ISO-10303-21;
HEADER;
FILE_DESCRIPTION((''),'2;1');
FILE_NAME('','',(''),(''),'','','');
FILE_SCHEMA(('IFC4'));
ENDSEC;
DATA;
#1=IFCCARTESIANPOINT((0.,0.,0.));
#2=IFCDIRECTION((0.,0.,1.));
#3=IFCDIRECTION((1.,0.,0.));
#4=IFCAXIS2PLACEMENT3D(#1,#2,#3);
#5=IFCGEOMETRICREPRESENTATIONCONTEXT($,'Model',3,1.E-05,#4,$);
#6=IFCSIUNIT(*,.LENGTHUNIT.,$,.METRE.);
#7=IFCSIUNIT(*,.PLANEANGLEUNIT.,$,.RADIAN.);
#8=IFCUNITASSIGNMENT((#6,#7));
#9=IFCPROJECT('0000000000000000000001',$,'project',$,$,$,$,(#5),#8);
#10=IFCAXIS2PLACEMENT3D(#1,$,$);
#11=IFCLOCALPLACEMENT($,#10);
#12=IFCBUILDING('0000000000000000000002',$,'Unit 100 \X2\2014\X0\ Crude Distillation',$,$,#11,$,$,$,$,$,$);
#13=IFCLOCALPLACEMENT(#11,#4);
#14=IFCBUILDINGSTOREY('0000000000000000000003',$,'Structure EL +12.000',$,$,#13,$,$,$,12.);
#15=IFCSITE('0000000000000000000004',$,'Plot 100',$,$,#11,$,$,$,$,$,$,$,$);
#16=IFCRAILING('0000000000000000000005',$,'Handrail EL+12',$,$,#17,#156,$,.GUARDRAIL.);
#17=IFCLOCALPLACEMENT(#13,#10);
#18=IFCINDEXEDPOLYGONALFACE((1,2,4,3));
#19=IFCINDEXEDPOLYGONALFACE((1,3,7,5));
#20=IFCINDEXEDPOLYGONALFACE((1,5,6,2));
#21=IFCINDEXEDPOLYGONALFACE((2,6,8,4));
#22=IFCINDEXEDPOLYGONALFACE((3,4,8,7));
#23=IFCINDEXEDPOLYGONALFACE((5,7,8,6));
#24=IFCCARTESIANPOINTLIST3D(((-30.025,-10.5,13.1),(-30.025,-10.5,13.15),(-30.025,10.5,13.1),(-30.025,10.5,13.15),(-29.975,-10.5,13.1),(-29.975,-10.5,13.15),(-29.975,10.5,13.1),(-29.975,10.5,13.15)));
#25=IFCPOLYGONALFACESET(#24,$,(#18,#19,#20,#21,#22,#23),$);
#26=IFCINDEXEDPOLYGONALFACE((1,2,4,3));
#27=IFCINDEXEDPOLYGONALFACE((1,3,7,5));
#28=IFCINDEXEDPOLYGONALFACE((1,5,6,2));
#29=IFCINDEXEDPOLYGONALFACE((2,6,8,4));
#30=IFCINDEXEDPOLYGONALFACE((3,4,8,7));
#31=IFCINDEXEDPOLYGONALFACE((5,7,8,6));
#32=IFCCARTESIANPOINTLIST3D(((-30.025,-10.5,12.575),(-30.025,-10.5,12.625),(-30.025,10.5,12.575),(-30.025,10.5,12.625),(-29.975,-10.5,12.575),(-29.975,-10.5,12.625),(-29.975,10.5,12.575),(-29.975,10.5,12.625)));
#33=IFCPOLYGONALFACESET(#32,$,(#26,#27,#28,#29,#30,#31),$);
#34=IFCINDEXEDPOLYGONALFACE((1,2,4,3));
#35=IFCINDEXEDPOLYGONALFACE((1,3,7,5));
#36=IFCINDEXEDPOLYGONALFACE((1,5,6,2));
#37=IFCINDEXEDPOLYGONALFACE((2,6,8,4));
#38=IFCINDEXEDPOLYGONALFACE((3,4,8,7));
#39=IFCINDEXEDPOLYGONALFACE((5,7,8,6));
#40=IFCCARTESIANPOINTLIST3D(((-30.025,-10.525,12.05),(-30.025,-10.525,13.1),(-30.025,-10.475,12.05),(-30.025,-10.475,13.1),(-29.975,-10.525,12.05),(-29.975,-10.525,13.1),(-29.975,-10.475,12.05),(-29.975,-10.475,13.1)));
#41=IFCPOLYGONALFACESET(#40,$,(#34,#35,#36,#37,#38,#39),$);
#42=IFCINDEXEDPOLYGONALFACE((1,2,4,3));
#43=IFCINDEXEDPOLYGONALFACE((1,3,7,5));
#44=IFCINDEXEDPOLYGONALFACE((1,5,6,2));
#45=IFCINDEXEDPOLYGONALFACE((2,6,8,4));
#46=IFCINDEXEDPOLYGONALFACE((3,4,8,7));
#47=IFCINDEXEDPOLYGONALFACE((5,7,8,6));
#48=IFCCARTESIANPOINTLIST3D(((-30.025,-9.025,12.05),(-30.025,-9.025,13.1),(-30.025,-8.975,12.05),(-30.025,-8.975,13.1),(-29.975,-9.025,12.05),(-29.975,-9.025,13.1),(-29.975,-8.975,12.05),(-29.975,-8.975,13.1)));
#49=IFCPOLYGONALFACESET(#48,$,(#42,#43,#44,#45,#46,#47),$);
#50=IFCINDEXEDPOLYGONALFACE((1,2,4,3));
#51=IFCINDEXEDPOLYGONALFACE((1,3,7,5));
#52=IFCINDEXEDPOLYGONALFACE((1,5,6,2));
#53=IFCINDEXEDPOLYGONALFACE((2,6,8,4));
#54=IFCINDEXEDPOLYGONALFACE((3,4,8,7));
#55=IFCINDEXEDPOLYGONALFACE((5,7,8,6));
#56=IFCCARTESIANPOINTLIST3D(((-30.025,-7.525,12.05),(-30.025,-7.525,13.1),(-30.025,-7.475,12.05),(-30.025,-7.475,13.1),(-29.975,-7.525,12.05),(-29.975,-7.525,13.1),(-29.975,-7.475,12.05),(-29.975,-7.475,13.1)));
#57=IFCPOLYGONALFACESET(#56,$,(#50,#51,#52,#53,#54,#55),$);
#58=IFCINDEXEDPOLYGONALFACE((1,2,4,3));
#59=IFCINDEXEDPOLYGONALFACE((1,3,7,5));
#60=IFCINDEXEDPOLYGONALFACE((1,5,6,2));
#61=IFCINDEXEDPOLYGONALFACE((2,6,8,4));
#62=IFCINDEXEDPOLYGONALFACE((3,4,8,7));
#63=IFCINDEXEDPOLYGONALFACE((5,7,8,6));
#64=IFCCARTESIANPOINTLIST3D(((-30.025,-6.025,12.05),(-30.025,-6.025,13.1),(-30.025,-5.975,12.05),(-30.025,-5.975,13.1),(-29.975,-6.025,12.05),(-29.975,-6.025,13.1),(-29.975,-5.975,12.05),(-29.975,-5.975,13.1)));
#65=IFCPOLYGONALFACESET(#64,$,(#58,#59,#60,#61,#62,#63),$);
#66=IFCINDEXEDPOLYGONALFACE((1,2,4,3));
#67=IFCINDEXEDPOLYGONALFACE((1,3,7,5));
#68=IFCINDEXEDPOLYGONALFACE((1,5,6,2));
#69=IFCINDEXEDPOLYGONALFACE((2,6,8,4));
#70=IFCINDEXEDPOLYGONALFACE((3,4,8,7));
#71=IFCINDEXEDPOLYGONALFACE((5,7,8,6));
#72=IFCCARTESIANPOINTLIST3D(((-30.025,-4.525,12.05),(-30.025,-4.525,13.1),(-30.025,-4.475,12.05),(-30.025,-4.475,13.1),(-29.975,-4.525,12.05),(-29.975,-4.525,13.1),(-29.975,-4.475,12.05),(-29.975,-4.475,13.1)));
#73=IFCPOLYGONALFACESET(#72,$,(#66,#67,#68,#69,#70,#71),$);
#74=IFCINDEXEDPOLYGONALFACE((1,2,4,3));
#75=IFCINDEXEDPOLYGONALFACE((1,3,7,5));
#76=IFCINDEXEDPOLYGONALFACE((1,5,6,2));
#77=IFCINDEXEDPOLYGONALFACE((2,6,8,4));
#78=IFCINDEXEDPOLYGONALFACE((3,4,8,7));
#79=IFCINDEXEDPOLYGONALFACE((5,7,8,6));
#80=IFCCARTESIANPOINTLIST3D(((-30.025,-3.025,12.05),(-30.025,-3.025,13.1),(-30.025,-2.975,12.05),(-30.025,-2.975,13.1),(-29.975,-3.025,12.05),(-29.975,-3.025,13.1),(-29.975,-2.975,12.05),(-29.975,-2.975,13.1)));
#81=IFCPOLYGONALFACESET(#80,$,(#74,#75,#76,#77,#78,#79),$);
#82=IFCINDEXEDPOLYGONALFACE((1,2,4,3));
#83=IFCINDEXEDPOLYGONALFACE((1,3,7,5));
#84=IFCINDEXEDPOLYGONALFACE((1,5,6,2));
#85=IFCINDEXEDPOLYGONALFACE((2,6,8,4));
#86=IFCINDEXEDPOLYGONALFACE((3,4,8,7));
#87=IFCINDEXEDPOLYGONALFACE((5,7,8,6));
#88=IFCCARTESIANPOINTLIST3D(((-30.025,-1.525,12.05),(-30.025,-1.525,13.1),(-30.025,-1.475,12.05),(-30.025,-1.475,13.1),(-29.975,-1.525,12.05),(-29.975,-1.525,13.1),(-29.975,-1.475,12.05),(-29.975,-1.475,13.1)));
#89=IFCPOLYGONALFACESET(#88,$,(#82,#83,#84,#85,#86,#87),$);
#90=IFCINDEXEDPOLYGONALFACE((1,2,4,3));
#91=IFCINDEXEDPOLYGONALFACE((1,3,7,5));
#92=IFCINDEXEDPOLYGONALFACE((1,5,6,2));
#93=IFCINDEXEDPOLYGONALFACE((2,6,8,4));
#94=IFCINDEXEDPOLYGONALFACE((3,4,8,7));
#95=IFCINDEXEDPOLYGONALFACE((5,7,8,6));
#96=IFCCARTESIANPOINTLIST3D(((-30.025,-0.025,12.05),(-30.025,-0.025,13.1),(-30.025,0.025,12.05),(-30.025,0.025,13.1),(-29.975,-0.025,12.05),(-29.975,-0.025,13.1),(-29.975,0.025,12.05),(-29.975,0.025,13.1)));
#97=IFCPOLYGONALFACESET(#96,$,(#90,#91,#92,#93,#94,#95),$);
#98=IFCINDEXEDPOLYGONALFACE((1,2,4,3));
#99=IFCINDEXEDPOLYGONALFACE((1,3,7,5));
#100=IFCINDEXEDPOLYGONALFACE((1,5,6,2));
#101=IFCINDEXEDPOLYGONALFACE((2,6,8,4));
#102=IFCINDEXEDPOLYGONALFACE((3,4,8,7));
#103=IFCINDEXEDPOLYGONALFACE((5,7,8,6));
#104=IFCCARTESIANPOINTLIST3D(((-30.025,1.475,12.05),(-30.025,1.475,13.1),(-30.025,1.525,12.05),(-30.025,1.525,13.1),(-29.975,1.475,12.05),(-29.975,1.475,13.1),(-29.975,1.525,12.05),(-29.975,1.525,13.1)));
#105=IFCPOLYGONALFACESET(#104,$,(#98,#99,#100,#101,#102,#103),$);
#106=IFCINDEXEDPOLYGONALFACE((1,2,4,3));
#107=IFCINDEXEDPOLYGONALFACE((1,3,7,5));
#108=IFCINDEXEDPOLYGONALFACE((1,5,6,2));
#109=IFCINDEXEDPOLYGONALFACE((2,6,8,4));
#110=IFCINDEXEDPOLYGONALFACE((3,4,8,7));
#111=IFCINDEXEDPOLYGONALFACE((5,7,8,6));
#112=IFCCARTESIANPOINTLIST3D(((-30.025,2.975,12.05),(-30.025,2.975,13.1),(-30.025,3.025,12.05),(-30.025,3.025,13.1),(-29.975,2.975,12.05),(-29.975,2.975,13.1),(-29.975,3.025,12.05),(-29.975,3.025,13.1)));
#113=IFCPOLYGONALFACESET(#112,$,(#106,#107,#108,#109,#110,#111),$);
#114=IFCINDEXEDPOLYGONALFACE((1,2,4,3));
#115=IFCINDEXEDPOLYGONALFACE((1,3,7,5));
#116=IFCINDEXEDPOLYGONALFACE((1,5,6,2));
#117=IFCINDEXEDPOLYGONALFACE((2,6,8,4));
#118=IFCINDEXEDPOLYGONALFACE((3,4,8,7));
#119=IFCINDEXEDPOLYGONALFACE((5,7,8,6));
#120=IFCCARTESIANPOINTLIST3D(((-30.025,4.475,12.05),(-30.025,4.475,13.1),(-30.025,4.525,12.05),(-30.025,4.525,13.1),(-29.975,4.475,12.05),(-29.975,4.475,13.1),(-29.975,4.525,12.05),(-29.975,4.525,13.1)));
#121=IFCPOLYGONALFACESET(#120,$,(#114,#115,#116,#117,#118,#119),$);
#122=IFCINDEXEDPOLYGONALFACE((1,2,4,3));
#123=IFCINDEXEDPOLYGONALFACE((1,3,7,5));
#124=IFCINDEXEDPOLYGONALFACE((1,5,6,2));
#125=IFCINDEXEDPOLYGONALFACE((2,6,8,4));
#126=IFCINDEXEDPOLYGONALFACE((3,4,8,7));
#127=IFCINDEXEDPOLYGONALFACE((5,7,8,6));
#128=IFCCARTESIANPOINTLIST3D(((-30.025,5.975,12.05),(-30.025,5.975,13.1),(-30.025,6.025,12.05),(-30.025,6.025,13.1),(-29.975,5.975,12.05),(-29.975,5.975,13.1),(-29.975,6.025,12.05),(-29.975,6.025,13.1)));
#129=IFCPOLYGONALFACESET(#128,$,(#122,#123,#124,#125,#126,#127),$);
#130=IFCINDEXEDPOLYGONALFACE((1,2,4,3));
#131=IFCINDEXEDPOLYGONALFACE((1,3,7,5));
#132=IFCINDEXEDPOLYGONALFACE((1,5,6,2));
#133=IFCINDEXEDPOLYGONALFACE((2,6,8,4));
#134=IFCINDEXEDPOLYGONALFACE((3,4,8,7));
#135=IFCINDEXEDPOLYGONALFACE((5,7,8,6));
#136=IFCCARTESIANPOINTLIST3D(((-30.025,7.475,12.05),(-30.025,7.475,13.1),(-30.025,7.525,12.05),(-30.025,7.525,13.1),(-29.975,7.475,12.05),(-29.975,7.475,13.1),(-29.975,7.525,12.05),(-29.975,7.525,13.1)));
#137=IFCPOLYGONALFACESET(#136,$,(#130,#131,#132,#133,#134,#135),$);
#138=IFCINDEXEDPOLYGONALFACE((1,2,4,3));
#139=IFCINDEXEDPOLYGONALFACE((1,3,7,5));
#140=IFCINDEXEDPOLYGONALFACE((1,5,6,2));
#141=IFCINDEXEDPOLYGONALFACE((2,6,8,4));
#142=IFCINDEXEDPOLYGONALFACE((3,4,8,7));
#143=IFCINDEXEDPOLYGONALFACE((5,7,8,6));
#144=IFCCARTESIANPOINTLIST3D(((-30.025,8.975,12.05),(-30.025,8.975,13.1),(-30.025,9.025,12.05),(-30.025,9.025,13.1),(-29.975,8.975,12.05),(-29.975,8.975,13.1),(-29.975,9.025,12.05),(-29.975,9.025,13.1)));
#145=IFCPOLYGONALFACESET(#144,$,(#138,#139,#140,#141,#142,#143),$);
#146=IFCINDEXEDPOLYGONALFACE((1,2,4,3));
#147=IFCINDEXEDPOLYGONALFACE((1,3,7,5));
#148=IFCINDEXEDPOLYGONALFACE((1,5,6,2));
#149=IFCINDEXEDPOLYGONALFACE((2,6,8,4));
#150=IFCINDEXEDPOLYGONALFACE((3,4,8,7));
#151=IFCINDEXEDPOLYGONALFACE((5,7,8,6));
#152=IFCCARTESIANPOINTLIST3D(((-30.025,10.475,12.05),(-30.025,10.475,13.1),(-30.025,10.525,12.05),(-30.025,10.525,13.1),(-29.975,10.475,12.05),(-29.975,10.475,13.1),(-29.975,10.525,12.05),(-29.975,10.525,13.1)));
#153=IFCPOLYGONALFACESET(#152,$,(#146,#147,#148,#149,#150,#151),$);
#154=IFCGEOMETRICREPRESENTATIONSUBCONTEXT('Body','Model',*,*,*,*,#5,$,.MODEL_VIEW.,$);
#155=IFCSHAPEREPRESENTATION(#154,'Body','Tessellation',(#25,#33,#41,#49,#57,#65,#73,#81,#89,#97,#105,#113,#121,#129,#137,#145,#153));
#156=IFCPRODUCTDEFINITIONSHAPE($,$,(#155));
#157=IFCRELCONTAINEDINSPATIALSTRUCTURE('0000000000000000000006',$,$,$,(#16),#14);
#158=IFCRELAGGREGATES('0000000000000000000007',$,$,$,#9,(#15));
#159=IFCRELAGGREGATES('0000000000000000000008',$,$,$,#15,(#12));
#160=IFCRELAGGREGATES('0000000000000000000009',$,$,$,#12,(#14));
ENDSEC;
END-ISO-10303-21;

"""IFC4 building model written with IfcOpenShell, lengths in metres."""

from ifc_helpers import new_model, si_unit, frame, origin, origin_with_axes, origin_2d, place, context, subcontext, project, spatial, rectangle, extrude, element, save


model = new_model("IFC4")

# Units and contexts
model_context = context("Model", 3, precision=1e-05, world=origin_with_axes())
body_context = subcontext(model_context, "Body", "Model", "MODEL_VIEW")
ifc_project = project(units=[si_unit("LENGTHUNIT", "METRE"), si_unit("PLANEANGLEUNIT", "RADIAN")], contexts=[model_context])

# Site, building, storey
placement = place(None, origin())
site = spatial("IfcSite", under=ifc_project, at=placement, Name="Plot 100")
building = spatial("IfcBuilding", under=site, at=placement, Name="Unit 100 — Crude Distillation")
storey_placement = place(placement, origin_with_axes())
storey = spatial("IfcBuildingStorey", under=building, at=storey_placement, Name="Structure EL +12.000", Elevation=12.0)

# Railing
railing_1_placement = place(storey_placement, origin_with_axes())
element("IfcRailing", 1, at=railing_1_placement, inside=storey, Name="Handrail EL+12", PredefinedType="GUARDRAIL", context=body_context, shape_type="SweptSolid", body=[
    extrude(rectangle(XDim=0.05, YDim=0.05, at=origin_2d()), frame((-30.0, -10.5, 13.125), z_axis=(0.0, 1.0, 0.0), x_axis=(-1.0, 0.0, 0.0)), (0.0, 0.0, 1.0), 21.0),
    extrude(rectangle(XDim=0.05, YDim=0.05, at=origin_2d()), frame((-30.0, -10.5, 12.6), z_axis=(0.0, 1.0, 0.0), x_axis=(-1.0, 0.0, 0.0)), (0.0, 0.0, 1.0), 21.0),
    extrude(rectangle(XDim=0.05, YDim=0.05, at=origin_2d()), frame((-30.0, -10.5, 12.05), z_axis=(0.0, 0.0, 1.0), x_axis=(1.0, 0.0, 0.0)), (0.0, 0.0, 1.0), 1.05),
    extrude(rectangle(XDim=0.05, YDim=0.05, at=origin_2d()), frame((-30.0, -9.0, 12.05), z_axis=(0.0, 0.0, 1.0), x_axis=(1.0, 0.0, 0.0)), (0.0, 0.0, 1.0), 1.05),
    extrude(rectangle(XDim=0.05, YDim=0.05, at=origin_2d()), frame((-30.0, -7.5, 12.05), z_axis=(0.0, 0.0, 1.0), x_axis=(1.0, 0.0, 0.0)), (0.0, 0.0, 1.0), 1.05),
    extrude(rectangle(XDim=0.05, YDim=0.05, at=origin_2d()), frame((-30.0, -6.0, 12.05), z_axis=(0.0, 0.0, 1.0), x_axis=(1.0, 0.0, 0.0)), (0.0, 0.0, 1.0), 1.05),
    extrude(rectangle(XDim=0.05, YDim=0.05, at=origin_2d()), frame((-30.0, -4.5, 12.05), z_axis=(0.0, 0.0, 1.0), x_axis=(1.0, 0.0, 0.0)), (0.0, 0.0, 1.0), 1.05),
    extrude(rectangle(XDim=0.05, YDim=0.05, at=origin_2d()), frame((-30.0, -3.0, 12.05), z_axis=(0.0, 0.0, 1.0), x_axis=(1.0, 0.0, 0.0)), (0.0, 0.0, 1.0), 1.05),
    extrude(rectangle(XDim=0.05, YDim=0.05, at=origin_2d()), frame((-30.0, -1.5, 12.05), z_axis=(0.0, 0.0, 1.0), x_axis=(1.0, 0.0, 0.0)), (0.0, 0.0, 1.0), 1.05),
    extrude(rectangle(XDim=0.05, YDim=0.05, at=origin_2d()), frame((-30.0, 0.0, 12.05), z_axis=(0.0, 0.0, 1.0), x_axis=(1.0, 0.0, 0.0)), (0.0, 0.0, 1.0), 1.05),
    extrude(rectangle(XDim=0.05, YDim=0.05, at=origin_2d()), frame((-30.0, 1.5, 12.05), z_axis=(0.0, 0.0, 1.0), x_axis=(1.0, 0.0, 0.0)), (0.0, 0.0, 1.0), 1.05),
    extrude(rectangle(XDim=0.05, YDim=0.05, at=origin_2d()), frame((-30.0, 3.0, 12.05), z_axis=(0.0, 0.0, 1.0), x_axis=(1.0, 0.0, 0.0)), (0.0, 0.0, 1.0), 1.05),
    extrude(rectangle(XDim=0.05, YDim=0.05, at=origin_2d()), frame((-30.0, 4.5, 12.05), z_axis=(0.0, 0.0, 1.0), x_axis=(1.0, 0.0, 0.0)), (0.0, 0.0, 1.0), 1.05),
    extrude(rectangle(XDim=0.05, YDim=0.05, at=origin_2d()), frame((-30.0, 6.0, 12.05), z_axis=(0.0, 0.0, 1.0), x_axis=(1.0, 0.0, 0.0)), (0.0, 0.0, 1.0), 1.05),
    extrude(rectangle(XDim=0.05, YDim=0.05, at=origin_2d()), frame((-30.0, 7.5, 12.05), z_axis=(0.0, 0.0, 1.0), x_axis=(1.0, 0.0, 0.0)), (0.0, 0.0, 1.0), 1.05),
    extrude(rectangle(XDim=0.05, YDim=0.05, at=origin_2d()), frame((-30.0, 9.0, 12.05), z_axis=(0.0, 0.0, 1.0), x_axis=(1.0, 0.0, 0.0)), (0.0, 0.0, 1.0), 1.05),
    extrude(rectangle(XDim=0.05, YDim=0.05, at=origin_2d()), frame((-30.0, 10.5, 12.05), z_axis=(0.0, 0.0, 1.0), x_axis=(1.0, 0.0, 0.0)), (0.0, 0.0, 1.0), 1.05),
])

save(model, "model.ifc")
